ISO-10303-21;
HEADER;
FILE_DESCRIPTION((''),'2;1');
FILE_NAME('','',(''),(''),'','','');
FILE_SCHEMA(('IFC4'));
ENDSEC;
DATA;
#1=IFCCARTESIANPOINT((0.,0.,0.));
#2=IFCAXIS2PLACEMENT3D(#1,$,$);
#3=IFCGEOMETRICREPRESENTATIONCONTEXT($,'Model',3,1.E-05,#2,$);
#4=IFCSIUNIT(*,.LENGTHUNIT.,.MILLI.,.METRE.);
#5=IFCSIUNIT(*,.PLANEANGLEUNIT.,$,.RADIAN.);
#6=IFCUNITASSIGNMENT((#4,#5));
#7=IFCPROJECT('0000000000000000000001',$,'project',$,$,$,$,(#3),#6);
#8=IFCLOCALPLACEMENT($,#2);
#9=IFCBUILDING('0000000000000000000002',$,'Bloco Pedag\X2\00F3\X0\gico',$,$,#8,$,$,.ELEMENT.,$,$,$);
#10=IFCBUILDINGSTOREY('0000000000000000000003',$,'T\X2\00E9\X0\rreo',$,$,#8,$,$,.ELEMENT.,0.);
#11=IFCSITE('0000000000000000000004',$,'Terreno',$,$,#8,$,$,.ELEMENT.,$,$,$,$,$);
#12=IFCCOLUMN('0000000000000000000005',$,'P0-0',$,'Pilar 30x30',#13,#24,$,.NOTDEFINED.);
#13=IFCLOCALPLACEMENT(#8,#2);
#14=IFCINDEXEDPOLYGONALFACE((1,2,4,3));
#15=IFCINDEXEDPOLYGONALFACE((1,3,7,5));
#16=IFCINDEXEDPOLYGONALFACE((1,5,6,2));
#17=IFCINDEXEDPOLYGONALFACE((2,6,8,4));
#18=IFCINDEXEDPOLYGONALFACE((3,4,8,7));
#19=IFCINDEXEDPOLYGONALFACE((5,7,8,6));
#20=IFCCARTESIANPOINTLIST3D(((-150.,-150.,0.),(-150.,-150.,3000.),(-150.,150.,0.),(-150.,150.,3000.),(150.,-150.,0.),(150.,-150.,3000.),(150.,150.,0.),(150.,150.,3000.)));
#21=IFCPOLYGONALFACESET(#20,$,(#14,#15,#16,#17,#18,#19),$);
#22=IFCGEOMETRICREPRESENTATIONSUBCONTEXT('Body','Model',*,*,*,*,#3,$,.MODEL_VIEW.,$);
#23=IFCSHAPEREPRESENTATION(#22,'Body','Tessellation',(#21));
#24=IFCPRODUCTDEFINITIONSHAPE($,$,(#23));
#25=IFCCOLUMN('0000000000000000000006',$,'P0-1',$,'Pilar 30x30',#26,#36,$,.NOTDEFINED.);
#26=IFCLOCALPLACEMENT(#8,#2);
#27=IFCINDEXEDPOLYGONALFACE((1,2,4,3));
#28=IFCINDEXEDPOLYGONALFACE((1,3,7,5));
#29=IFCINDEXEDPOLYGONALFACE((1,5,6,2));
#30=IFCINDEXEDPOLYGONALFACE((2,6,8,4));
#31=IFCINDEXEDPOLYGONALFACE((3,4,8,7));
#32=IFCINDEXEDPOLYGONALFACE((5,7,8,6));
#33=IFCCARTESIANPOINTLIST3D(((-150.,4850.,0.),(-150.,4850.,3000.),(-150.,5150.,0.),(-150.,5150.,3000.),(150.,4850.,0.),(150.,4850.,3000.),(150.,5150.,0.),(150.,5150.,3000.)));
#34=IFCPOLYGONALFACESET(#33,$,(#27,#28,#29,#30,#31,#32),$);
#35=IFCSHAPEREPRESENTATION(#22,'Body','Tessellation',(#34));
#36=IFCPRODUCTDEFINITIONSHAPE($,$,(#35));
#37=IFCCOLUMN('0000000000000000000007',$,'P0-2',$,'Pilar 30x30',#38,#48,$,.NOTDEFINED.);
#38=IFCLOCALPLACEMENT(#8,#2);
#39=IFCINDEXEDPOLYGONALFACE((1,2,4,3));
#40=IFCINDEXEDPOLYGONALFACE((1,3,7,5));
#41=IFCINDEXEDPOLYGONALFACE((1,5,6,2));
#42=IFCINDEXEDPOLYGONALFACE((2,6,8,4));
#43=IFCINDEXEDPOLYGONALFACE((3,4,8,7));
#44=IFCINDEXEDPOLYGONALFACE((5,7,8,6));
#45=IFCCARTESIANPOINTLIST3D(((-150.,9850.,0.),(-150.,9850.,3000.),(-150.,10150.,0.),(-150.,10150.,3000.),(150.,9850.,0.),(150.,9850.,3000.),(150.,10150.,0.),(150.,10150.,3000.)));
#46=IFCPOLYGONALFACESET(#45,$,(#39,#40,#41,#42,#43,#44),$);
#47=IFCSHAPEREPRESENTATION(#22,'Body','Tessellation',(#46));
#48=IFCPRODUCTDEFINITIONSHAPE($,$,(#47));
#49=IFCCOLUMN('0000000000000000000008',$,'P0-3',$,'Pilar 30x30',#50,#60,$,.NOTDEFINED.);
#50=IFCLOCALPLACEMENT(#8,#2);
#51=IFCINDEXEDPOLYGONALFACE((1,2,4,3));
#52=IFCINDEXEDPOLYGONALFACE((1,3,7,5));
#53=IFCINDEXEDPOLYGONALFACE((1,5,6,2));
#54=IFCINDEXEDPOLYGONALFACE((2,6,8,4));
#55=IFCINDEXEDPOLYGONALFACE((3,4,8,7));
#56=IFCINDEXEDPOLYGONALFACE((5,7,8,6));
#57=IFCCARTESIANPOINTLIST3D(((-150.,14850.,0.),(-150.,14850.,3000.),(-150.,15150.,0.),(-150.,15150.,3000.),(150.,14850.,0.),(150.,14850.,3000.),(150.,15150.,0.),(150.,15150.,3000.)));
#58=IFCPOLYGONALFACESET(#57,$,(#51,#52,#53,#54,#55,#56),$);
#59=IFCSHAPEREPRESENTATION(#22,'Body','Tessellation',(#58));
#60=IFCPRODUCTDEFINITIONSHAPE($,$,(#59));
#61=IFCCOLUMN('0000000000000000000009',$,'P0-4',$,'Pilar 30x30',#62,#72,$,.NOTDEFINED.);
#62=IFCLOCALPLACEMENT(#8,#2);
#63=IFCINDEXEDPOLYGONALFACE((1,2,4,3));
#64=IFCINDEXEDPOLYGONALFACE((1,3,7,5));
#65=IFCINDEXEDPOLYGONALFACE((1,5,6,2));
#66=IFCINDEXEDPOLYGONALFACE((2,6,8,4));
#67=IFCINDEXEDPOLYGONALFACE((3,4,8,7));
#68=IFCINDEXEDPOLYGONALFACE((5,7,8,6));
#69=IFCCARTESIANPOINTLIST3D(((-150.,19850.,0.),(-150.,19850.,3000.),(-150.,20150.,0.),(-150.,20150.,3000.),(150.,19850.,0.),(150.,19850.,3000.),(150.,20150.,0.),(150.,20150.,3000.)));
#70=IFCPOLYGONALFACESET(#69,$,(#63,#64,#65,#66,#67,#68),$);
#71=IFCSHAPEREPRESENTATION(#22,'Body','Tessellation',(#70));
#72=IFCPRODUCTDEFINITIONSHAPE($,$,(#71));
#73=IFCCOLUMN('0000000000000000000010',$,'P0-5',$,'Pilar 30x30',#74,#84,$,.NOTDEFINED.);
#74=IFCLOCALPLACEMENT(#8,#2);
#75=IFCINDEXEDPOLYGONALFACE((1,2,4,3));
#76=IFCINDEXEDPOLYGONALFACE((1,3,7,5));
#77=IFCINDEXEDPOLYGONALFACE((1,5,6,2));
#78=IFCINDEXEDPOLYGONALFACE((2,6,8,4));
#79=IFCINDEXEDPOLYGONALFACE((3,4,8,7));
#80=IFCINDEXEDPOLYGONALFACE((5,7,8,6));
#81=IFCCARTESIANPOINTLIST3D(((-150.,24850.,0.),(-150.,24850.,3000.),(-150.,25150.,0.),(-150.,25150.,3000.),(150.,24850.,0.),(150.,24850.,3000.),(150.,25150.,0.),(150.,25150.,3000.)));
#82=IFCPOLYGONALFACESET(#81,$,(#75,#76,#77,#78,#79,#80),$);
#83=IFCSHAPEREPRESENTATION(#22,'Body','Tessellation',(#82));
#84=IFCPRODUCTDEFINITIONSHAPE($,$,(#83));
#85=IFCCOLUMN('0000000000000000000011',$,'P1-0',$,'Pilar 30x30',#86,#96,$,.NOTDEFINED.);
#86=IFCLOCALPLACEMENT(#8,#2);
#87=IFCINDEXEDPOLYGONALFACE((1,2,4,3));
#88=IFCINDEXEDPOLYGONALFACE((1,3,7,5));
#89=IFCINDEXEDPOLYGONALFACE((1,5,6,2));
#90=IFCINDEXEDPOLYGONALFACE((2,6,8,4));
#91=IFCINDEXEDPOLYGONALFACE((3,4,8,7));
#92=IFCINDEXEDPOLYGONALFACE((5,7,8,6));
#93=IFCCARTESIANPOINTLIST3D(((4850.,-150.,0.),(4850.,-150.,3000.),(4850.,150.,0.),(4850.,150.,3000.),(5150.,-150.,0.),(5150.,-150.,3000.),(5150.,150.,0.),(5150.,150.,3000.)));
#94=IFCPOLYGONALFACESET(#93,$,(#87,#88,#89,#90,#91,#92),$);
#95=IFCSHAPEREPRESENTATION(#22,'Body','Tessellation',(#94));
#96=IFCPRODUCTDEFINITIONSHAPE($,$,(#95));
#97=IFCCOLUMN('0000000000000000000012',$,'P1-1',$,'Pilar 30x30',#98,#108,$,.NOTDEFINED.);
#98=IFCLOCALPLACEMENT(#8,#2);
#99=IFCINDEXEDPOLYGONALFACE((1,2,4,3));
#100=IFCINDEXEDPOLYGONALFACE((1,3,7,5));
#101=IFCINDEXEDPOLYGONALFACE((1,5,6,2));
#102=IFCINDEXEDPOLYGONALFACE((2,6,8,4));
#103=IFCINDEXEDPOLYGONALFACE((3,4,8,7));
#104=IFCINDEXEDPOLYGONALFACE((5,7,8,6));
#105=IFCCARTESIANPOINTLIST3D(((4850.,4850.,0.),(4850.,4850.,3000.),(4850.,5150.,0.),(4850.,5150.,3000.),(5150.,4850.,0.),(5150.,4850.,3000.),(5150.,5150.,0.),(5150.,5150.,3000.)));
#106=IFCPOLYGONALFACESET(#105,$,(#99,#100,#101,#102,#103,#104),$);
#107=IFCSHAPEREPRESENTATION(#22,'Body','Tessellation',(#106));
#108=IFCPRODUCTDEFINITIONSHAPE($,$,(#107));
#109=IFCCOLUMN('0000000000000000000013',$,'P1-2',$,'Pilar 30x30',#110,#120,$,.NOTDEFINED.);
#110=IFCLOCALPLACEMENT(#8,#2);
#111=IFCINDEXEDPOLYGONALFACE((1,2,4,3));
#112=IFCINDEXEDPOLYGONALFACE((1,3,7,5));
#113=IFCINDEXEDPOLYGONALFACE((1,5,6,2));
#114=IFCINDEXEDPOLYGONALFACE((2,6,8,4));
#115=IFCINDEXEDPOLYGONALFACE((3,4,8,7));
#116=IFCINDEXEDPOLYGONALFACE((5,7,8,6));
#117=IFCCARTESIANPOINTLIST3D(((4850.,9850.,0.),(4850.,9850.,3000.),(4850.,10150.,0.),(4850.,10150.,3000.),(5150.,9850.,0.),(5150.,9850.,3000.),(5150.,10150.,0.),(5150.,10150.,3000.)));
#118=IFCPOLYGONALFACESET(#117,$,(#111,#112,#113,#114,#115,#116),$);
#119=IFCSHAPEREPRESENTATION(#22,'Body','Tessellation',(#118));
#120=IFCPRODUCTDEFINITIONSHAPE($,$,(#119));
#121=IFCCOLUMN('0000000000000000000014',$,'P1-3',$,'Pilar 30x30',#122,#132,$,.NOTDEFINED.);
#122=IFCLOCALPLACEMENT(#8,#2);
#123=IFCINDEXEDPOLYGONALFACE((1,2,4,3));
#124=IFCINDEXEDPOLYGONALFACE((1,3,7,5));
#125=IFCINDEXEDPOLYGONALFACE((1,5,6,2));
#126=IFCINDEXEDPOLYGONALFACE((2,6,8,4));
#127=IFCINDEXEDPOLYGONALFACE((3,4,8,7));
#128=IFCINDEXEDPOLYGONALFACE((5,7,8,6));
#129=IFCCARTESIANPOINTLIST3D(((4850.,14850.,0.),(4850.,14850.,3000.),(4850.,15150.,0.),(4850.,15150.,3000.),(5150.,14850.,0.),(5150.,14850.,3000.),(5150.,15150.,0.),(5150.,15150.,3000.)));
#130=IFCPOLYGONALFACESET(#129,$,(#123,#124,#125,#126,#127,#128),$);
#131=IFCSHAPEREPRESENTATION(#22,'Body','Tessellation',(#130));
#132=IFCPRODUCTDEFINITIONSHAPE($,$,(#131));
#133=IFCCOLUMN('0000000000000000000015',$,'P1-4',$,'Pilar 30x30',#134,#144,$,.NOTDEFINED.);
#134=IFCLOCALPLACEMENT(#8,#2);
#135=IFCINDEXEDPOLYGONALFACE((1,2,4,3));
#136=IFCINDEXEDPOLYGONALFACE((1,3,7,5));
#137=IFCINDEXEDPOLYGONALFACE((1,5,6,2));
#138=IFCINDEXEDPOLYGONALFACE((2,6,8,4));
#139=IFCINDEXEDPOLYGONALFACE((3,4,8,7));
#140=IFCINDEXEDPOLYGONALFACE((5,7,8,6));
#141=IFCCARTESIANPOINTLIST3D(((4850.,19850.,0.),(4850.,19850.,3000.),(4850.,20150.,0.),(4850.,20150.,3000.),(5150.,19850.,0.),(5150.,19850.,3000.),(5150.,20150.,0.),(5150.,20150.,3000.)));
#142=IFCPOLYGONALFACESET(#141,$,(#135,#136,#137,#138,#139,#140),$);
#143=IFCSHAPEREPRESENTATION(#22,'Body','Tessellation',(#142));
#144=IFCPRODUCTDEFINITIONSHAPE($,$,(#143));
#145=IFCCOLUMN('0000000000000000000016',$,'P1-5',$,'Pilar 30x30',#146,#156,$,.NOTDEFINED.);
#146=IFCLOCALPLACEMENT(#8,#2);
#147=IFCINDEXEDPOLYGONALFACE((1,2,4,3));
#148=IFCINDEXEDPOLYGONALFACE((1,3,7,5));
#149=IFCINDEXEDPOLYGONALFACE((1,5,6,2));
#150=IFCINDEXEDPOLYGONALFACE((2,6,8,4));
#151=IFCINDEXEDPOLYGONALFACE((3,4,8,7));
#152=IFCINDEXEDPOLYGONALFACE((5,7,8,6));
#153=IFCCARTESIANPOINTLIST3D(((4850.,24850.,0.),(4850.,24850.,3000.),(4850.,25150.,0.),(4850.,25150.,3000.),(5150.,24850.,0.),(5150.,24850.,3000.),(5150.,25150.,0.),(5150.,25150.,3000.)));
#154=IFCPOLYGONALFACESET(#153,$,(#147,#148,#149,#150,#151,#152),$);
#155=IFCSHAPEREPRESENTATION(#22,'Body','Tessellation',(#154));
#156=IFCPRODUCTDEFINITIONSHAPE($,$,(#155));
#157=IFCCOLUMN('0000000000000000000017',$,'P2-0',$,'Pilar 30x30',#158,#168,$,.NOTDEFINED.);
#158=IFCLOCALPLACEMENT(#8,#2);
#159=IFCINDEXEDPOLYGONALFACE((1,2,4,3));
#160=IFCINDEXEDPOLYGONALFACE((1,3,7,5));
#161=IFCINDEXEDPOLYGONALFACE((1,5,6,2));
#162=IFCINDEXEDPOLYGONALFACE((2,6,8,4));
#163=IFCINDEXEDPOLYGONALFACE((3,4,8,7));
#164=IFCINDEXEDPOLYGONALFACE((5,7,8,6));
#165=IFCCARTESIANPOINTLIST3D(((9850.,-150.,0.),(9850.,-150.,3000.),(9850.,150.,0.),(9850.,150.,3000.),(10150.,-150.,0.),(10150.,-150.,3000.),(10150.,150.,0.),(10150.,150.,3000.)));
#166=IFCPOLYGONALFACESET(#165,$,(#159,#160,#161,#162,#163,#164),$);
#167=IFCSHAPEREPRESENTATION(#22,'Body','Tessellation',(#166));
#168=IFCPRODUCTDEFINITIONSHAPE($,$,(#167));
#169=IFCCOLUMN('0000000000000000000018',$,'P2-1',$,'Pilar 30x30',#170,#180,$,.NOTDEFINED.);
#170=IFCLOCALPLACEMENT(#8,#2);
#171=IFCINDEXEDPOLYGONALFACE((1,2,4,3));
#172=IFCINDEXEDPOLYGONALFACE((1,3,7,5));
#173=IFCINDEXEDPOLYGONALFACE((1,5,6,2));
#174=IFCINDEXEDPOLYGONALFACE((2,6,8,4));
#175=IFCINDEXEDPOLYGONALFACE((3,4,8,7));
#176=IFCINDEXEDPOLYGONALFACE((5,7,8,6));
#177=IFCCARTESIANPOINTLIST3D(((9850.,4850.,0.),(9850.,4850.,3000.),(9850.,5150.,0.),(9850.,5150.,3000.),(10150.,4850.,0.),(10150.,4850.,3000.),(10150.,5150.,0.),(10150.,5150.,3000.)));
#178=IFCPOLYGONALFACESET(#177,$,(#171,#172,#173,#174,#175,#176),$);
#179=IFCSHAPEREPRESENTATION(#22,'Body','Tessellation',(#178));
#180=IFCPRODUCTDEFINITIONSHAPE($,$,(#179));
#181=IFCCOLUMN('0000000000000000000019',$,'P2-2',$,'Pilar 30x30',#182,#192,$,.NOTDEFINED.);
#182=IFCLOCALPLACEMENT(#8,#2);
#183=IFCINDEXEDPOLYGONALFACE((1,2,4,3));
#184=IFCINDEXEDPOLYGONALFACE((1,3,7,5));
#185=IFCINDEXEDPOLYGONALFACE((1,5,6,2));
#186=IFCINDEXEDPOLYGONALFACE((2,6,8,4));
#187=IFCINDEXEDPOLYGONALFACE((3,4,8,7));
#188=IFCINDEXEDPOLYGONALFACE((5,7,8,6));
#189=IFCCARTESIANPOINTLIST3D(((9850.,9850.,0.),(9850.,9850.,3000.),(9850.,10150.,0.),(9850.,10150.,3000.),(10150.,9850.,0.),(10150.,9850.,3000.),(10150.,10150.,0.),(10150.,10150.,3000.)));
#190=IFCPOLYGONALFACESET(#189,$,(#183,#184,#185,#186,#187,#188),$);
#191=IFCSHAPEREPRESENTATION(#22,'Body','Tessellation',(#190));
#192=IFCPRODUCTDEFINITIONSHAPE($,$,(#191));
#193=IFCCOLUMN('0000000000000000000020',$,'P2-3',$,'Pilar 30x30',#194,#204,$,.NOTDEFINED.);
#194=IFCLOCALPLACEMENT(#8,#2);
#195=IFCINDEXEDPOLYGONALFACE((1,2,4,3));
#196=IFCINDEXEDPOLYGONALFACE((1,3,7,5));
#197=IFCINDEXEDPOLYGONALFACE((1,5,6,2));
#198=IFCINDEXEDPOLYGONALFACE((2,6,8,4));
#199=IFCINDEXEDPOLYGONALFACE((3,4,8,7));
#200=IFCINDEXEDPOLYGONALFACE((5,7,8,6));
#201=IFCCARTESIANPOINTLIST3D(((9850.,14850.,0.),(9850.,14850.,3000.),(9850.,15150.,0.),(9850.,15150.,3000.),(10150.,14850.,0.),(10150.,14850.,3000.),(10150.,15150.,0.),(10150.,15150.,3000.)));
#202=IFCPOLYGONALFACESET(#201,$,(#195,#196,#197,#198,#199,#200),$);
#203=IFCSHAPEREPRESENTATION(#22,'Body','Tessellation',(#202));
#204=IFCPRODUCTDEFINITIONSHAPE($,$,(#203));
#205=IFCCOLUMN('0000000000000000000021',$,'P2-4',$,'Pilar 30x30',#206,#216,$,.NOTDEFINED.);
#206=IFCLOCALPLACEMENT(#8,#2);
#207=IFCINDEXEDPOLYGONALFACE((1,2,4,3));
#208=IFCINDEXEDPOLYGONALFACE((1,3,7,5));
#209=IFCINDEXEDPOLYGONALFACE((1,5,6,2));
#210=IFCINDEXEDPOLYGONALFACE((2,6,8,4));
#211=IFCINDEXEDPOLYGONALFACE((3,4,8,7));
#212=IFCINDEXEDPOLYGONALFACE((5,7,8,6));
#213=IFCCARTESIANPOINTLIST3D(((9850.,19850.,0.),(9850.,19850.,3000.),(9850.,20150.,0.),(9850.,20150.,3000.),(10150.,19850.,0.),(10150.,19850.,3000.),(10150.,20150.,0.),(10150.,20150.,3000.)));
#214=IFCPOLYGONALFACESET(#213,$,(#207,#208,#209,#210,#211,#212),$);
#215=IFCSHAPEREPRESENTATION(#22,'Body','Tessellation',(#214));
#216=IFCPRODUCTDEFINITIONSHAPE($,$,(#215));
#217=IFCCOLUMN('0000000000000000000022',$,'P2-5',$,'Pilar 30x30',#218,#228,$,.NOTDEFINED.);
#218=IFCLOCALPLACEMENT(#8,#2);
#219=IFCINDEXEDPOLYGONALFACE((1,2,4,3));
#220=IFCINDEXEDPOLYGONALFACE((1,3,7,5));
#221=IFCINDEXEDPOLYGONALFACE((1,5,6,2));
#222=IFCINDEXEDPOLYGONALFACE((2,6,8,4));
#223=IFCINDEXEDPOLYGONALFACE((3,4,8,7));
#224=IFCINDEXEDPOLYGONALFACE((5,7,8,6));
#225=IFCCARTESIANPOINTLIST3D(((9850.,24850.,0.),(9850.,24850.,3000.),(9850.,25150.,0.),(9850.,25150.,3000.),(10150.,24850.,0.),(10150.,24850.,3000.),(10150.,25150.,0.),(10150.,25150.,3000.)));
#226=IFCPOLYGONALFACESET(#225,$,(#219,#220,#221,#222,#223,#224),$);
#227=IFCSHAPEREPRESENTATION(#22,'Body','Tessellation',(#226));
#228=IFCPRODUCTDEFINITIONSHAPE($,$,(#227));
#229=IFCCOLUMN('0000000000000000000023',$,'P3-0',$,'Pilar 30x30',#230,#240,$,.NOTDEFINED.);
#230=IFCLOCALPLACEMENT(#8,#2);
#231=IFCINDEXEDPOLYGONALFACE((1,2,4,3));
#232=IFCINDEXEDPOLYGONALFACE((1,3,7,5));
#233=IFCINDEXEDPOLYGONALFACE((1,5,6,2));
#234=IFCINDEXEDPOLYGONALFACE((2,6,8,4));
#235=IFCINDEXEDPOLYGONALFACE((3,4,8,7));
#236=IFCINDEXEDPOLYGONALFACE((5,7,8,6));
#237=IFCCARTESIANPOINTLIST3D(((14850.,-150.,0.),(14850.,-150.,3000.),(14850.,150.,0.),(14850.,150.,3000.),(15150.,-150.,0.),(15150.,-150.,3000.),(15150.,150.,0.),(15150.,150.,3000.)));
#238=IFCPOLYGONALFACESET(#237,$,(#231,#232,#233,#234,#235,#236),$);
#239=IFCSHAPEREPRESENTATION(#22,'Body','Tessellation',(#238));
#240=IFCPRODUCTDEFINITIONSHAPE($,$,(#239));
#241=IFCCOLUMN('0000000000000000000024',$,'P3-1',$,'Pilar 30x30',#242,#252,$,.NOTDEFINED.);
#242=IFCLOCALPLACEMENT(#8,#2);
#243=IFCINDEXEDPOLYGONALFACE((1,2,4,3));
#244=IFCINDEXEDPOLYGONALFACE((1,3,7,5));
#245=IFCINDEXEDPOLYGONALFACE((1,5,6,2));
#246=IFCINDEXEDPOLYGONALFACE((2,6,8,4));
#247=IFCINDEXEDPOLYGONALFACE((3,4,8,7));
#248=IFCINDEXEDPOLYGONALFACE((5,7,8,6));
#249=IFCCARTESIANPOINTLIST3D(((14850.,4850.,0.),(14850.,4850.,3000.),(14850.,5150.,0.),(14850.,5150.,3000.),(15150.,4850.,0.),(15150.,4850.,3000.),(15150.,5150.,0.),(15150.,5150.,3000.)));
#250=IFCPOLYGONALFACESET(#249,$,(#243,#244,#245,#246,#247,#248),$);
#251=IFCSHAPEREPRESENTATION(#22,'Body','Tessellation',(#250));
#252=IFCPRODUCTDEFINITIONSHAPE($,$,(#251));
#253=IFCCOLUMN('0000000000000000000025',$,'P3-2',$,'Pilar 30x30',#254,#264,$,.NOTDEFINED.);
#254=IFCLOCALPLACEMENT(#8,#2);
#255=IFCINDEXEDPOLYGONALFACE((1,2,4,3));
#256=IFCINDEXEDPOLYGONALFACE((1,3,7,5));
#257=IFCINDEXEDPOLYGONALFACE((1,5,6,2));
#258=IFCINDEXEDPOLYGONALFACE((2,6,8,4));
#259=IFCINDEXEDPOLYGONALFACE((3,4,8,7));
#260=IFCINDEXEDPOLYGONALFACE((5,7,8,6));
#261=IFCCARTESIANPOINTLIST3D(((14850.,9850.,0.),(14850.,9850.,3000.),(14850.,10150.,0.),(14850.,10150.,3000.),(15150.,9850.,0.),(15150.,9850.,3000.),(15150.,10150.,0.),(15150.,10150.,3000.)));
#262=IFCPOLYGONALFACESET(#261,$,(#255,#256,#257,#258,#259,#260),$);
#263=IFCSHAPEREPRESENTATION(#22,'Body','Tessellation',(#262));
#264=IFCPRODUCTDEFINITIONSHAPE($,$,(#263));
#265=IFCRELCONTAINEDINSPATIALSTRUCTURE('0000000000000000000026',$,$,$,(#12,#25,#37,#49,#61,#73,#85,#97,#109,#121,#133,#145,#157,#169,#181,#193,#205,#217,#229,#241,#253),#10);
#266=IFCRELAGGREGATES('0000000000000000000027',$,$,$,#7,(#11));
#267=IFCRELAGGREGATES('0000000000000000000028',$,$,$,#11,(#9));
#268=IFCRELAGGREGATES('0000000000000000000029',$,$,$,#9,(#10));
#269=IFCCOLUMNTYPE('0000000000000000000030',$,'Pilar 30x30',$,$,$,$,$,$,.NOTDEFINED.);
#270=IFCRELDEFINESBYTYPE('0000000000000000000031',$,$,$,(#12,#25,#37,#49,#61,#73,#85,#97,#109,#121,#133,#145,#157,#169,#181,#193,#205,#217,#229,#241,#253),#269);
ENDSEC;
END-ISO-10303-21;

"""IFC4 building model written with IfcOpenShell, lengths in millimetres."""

from ifc_helpers import new_model, si_unit, frame, origin, origin_2d, place, context, subcontext, project, spatial, rectangle, extrude, type_object, element, save


model = new_model("IFC4")

# Units and contexts
model_context = context("Model", 3, precision=1e-05, world=origin())
body_context = subcontext(model_context, "Body", "Model", "MODEL_VIEW")
ifc_project = project(units=[si_unit("LENGTHUNIT", "METRE", prefix="MILLI"), si_unit("PLANEANGLEUNIT", "RADIAN")], contexts=[model_context])

# Site, building, storey
placement = place(None, origin())
site = spatial("IfcSite", under=ifc_project, at=placement, Name="Terreno", CompositionType="ELEMENT")
building = spatial("IfcBuilding", under=site, at=placement, Name="Bloco Pedagógico", CompositionType="ELEMENT")
storey = spatial("IfcBuildingStorey", under=building, at=placement, Name="Térreo", CompositionType="ELEMENT", Elevation=0.0)

# Columns
column_type = type_object("IfcColumnType", Name="Pilar 30x30", PredefinedType="NOTDEFINED")
for number, where, z_axis, x_axis, name in (
    (1, (0.0, 0.0, 0.0), (0.0, 0.0, 1.0), (1.0, 0.0, 0.0), "P0-0"),
    (2, (0.0, 5000.0, 0.0), (0.0, 0.0, 1.0), (1.0, 0.0, 0.0), "P0-1"),
    (3, (0.0, 10000.0, 0.0), (0.0, 0.0, 1.0), (1.0, 0.0, 0.0), "P0-2"),
    (4, (0.0, 15000.0, 0.0), (0.0, 0.0, 1.0), (1.0, 0.0, 0.0), "P0-3"),
    (5, (0.0, 20000.0, 0.0), (0.0, 0.0, 1.0), (1.0, 0.0, 0.0), "P0-4"),
    (6, (0.0, 25000.0, 0.0), (0.0, 0.0, 1.0), (1.0, 0.0, 0.0), "P0-5"),
    (7, (5000.0, 0.0, 0.0), (0.0, 0.0, 1.0), (1.0, 0.0, 0.0), "P1-0"),
    (8, (5000.0, 5000.0, 0.0), (0.0, 0.0, 1.0), (1.0, 0.0, 0.0), "P1-1"),
    (9, (5000.0, 10000.0, 0.0), (0.0, 0.0, 1.0), (1.0, 0.0, 0.0), "P1-2"),
    (10, (5000.0, 15000.0, 0.0), (0.0, 0.0, 1.0), (1.0, 0.0, 0.0), "P1-3"),
    (11, (5000.0, 20000.0, 0.0), (0.0, 0.0, 1.0), (1.0, 0.0, 0.0), "P1-4"),
    (12, (5000.0, 25000.0, 0.0), (0.0, 0.0, 1.0), (1.0, 0.0, 0.0), "P1-5"),
    (13, (10000.0, 0.0, 0.0), (0.0, 0.0, 1.0), (1.0, 0.0, 0.0), "P2-0"),
    (14, (10000.0, 5000.0, 0.0), (0.0, 0.0, 1.0), (1.0, 0.0, 0.0), "P2-1"),
    (15, (10000.0, 10000.0, 0.0), (0.0, 0.0, 1.0), (1.0, 0.0, 0.0), "P2-2"),
    (16, (10000.0, 15000.0, 0.0), (0.0, 0.0, 1.0), (1.0, 0.0, 0.0), "P2-3"),
    (17, (10000.0, 20000.0, 0.0), (0.0, 0.0, 1.0), (1.0, 0.0, 0.0), "P2-4"),
    (18, (10000.0, 25000.0, 0.0), (0.0, 0.0, 1.0), (1.0, 0.0, 0.0), "P2-5"),
    (19, (15000.0, 0.0, 0.0), (0.0, 0.0, 1.0), (1.0, 0.0, 0.0), "P3-0"),
    (20, (15000.0, 5000.0, 0.0), (0.0, 0.0, 1.0), (1.0, 0.0, 0.0), "P3-1"),
    (21, (15000.0, 10000.0, 0.0), (0.0, 0.0, 1.0), (1.0, 0.0, 0.0), "P3-2"),
):
    element("IfcColumn", number, at=place(None, frame(where, z_axis=z_axis, x_axis=x_axis)), inside=storey, type_object=column_type, Name=name, ObjectType="Pilar 30x30", PredefinedType="NOTDEFINED", context=body_context, shape_type="SweptSolid", body=[
        extrude(rectangle(XDim=300.0, YDim=300.0, at=origin_2d()), None, (0.0, 0.0, 1.0), 3000.0),
    ])

save(model, "model.ifc")
